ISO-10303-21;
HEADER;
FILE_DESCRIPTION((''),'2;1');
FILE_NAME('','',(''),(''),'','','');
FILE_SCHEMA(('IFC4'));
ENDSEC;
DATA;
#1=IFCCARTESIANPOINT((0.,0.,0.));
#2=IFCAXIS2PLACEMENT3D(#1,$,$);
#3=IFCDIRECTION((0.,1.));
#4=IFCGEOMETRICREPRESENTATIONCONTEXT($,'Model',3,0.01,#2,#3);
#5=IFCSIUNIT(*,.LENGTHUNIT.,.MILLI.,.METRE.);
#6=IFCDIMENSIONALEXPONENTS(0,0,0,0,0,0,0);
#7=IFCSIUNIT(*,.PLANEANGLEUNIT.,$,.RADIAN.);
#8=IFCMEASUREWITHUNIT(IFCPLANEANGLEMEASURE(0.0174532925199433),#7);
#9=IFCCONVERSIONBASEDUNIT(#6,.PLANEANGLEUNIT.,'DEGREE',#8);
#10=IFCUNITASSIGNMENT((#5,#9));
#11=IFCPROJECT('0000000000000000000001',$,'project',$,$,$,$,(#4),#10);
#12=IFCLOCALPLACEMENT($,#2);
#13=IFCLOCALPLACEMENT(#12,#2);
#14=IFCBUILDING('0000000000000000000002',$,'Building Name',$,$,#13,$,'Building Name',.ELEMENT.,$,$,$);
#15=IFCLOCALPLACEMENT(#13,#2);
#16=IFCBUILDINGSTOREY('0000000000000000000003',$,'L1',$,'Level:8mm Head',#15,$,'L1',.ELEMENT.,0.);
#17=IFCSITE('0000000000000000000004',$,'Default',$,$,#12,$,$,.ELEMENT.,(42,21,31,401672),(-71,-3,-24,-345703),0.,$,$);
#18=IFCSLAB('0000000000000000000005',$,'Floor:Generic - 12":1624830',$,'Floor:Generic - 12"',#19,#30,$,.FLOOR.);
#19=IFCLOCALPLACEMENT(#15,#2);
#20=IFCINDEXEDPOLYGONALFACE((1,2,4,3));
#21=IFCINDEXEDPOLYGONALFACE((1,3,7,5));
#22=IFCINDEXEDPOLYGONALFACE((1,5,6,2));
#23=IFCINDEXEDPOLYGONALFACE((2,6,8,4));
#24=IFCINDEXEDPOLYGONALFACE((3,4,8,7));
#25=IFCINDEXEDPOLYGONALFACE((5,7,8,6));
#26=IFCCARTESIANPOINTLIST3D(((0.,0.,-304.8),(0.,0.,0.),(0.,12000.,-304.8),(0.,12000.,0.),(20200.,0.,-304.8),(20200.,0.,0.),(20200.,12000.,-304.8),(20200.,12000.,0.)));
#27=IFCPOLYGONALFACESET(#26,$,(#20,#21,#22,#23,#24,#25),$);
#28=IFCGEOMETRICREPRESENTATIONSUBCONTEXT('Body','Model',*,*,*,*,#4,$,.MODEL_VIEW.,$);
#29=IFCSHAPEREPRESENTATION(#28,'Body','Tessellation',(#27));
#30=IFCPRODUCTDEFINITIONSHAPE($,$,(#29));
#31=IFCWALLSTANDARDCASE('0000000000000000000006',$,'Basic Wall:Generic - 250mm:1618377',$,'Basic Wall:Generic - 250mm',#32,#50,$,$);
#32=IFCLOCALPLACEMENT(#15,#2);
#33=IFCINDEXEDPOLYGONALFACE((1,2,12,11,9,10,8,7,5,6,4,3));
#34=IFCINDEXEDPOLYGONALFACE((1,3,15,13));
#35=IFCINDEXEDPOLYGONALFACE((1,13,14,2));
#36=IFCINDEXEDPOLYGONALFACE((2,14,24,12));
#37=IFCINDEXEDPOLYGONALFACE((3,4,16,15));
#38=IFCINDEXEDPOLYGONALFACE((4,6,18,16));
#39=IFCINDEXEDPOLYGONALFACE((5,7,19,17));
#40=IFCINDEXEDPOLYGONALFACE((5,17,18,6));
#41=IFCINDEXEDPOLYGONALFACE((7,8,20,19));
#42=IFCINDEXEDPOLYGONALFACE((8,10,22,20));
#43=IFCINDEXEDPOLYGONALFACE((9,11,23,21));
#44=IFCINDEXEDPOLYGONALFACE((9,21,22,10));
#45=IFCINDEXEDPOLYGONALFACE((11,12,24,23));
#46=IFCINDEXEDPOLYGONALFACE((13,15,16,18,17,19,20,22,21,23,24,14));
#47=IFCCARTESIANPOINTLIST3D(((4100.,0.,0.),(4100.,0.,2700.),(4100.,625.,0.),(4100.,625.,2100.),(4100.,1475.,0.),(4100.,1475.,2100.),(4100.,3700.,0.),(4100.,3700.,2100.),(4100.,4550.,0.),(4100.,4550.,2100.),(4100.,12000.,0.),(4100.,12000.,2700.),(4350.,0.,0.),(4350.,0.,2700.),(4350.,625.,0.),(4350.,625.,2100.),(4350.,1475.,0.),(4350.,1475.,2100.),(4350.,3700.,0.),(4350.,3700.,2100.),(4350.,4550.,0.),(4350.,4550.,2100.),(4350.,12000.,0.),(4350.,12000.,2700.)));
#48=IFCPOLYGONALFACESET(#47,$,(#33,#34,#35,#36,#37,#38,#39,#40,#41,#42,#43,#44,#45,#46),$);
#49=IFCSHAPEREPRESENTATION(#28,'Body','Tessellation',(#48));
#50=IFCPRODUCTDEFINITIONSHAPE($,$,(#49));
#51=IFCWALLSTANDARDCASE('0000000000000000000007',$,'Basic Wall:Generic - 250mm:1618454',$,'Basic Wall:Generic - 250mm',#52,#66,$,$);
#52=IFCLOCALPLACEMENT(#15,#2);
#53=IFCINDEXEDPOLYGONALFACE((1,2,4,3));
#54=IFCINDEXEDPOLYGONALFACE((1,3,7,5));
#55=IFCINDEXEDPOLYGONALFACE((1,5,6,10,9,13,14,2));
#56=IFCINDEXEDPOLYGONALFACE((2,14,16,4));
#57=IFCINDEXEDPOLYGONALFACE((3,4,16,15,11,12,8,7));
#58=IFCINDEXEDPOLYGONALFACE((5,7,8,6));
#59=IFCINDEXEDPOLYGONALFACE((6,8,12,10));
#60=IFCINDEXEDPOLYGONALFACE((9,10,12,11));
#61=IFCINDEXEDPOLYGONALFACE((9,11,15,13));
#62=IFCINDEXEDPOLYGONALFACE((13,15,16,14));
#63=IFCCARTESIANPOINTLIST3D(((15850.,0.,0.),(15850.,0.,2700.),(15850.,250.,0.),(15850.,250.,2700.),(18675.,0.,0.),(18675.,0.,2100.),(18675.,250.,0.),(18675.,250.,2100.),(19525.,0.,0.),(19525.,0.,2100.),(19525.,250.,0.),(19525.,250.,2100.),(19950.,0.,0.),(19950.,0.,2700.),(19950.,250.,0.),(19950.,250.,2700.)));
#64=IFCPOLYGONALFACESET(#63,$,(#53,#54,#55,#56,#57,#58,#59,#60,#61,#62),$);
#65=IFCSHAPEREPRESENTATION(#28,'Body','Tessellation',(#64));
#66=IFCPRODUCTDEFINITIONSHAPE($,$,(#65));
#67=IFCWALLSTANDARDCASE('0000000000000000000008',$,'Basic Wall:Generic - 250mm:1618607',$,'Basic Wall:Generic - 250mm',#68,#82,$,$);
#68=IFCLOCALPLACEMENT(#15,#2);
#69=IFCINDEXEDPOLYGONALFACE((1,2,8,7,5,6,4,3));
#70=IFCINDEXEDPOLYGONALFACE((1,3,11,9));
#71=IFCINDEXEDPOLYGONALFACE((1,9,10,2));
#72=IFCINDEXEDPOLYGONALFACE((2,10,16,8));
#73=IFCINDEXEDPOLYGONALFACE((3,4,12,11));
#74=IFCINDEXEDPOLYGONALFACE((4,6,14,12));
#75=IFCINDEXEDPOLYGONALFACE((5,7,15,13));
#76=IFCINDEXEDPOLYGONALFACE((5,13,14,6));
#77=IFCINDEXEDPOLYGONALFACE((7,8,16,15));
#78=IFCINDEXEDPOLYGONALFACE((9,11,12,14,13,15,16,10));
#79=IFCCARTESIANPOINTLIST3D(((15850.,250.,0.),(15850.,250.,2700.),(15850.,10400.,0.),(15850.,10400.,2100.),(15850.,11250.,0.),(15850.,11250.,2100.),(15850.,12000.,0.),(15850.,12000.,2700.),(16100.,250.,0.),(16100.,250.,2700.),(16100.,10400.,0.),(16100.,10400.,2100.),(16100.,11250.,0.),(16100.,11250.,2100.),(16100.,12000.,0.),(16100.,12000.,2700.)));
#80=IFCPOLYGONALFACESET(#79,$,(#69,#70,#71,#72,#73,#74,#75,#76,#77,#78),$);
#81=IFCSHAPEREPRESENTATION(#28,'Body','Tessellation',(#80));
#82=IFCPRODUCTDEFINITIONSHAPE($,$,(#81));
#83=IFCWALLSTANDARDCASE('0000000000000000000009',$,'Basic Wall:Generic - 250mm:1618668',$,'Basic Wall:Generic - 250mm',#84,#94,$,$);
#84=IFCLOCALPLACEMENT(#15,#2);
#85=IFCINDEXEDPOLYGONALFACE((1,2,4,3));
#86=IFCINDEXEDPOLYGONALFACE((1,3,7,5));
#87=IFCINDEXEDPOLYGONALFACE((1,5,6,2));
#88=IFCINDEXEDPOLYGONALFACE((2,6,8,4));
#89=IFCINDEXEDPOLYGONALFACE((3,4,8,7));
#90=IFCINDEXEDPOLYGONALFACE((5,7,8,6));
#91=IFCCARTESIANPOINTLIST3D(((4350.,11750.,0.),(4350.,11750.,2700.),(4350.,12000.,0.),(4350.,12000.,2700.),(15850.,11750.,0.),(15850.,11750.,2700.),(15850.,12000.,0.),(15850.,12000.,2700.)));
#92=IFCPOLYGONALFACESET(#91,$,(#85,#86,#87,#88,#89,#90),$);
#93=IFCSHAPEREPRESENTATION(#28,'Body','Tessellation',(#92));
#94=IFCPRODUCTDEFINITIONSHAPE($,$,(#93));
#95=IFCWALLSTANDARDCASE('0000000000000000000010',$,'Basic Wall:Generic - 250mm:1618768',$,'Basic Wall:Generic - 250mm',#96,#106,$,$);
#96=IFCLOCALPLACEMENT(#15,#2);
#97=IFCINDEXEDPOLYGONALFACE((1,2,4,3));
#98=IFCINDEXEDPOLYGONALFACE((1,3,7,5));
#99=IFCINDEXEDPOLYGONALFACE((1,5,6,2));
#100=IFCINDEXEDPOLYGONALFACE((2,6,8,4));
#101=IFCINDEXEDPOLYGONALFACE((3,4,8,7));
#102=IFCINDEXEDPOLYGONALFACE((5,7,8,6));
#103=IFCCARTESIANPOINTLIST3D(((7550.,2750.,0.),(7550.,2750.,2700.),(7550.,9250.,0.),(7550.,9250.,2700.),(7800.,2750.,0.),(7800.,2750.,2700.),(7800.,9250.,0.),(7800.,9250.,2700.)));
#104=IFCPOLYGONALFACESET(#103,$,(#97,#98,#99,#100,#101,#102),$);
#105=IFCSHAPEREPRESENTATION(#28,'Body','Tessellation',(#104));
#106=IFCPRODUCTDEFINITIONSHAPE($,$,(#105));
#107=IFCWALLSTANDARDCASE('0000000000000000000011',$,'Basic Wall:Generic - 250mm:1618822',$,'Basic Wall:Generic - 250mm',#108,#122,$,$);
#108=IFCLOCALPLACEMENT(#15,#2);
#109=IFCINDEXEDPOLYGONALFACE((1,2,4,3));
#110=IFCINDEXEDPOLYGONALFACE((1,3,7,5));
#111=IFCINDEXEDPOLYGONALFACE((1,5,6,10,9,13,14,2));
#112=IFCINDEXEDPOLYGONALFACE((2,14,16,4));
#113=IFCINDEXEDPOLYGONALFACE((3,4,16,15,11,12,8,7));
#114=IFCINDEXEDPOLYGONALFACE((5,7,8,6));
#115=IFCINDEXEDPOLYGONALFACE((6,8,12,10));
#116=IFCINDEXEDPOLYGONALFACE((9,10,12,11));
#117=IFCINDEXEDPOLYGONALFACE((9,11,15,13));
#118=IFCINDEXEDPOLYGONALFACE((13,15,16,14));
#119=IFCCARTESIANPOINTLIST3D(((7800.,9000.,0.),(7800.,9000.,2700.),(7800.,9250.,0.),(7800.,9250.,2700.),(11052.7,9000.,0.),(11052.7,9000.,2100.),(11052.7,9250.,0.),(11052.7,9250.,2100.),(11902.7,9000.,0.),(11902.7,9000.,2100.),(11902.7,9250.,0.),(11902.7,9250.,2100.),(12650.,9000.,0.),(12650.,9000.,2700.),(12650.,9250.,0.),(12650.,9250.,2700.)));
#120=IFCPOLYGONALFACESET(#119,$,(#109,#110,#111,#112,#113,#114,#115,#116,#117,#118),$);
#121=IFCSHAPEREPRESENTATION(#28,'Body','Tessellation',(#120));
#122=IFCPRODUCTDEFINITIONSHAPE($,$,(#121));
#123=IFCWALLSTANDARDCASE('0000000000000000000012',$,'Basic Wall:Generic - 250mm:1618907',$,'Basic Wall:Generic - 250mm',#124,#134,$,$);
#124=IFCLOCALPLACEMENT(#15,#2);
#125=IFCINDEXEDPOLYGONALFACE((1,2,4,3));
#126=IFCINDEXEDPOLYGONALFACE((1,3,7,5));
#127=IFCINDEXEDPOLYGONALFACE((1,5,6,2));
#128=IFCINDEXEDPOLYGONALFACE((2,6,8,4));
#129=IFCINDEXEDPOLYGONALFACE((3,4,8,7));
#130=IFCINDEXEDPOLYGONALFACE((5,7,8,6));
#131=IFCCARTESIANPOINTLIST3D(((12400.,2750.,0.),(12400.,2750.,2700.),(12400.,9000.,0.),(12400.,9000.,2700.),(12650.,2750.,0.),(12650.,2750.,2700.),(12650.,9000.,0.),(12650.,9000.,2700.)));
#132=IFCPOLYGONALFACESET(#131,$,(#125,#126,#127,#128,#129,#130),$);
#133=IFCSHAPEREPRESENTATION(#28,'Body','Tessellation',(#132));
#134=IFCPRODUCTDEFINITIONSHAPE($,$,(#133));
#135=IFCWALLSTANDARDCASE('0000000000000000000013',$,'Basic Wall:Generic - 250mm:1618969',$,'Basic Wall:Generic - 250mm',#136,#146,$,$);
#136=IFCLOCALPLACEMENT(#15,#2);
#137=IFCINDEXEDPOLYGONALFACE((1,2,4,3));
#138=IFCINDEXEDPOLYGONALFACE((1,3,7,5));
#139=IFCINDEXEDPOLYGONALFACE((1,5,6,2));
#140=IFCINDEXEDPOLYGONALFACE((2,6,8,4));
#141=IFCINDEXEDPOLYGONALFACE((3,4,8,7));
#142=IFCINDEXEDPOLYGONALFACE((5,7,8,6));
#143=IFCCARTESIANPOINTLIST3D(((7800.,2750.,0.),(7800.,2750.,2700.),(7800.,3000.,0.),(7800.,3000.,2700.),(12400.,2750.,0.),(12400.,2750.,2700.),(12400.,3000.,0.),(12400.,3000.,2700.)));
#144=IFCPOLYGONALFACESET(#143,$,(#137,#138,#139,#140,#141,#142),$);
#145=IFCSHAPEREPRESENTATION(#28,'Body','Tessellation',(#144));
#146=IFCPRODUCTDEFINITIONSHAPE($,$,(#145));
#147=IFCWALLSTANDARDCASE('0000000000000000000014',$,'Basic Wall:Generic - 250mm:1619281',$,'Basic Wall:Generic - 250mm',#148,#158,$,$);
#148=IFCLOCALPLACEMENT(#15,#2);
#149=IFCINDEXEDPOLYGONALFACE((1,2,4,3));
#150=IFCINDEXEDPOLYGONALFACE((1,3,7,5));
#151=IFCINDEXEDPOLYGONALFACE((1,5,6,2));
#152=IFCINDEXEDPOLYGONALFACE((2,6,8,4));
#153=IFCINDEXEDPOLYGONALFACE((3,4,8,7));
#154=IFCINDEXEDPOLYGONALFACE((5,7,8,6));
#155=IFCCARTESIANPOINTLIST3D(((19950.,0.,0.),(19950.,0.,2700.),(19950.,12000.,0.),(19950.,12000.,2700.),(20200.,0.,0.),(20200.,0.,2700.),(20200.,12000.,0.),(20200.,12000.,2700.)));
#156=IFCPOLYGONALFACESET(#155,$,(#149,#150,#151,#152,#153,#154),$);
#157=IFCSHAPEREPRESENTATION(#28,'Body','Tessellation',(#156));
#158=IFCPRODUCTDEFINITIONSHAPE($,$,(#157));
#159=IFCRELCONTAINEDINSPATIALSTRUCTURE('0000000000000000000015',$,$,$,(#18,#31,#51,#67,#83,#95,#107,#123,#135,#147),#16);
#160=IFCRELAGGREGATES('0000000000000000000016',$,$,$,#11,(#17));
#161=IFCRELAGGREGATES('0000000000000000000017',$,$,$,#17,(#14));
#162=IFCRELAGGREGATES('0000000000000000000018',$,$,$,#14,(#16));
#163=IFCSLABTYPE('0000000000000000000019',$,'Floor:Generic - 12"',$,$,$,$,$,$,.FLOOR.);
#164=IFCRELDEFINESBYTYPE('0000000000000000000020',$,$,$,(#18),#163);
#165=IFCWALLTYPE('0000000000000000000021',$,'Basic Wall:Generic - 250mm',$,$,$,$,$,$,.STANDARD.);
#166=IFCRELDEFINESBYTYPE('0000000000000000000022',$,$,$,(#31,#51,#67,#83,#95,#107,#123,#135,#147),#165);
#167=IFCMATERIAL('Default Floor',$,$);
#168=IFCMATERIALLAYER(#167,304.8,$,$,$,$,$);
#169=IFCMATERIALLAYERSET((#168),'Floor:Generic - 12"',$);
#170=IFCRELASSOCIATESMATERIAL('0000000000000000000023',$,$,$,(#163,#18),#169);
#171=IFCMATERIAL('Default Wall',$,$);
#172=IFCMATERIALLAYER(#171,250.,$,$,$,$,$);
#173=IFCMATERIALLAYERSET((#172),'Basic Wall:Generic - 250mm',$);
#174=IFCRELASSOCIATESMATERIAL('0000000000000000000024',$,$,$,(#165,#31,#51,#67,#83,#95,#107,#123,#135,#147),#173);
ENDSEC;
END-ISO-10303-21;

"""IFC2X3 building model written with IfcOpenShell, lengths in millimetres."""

from ifc_helpers import new_model, entity, si_unit, converted_unit, direction, frame, frame_2d, origin, origin_2d_with_axis, place, context, subcontext, project, spatial, rectangle, extrude, material, layer, layer_set, layer_usage, type_object, element, save


model = new_model("IFC2X3")

# Units and contexts
model_context = context("Model", 3, precision=0.01, world=origin(), true_north=direction((0.0, 1.0)))
body_context = subcontext(model_context, "Body", "Model", "MODEL_VIEW")
ifc_project = project(units=[si_unit("LENGTHUNIT", "METRE", prefix="MILLI"), converted_unit("PLANEANGLEUNIT", "DEGREE", entity("IfcPlaneAngleMeasure", 0.0174532925199433), si_unit("PLANEANGLEUNIT", "RADIAN"), dimensions=[0, 0, 0, 0, 0, 0, 0])], contexts=[model_context])

# Site, building, storey
site_placement = place(None, origin())
site = spatial("IfcSite", under=ifc_project, at=site_placement, Name="Default", CompositionType="ELEMENT", RefLatitude=(42, 21, 31, 401672), RefLongitude=(-71, -3, -24, -345703), RefElevation=0.0)
building_placement = place(site_placement, origin())
building = spatial("IfcBuilding", under=site, at=building_placement, Name="Building Name", LongName="Building Name", CompositionType="ELEMENT")
storey_placement = place(building_placement, origin())
storey = spatial("IfcBuildingStorey", under=building, at=storey_placement, Name="L1", ObjectType="Level:8mm Head", LongName="L1", CompositionType="ELEMENT", Elevation=0.0)

# Slab
ifc_material_1 = material(Name="Default Floor")
ifc_layer_1 = layer(ifc_material_1, 304.8)
ifc_layer_set_1 = layer_set([ifc_layer_1], Name="Floor:Generic - 12\"")
ifc_layer_usage_1 = layer_usage(ifc_layer_set_1, "AXIS3", "POSITIVE", 0.0)
slab_type = type_object("IfcSlabType", Name="Floor:Generic - 12\"", PredefinedType="FLOOR", material=ifc_layer_set_1)
slab_placement = place(storey_placement, origin())
element("IfcSlab", 1, at=slab_placement, inside=storey, type_object=slab_type, material=ifc_layer_usage_1, Name="Floor:Generic - 12\":1624830", ObjectType="Floor:Generic - 12\"", PredefinedType="FLOOR", context=body_context, shape_type="SweptSolid", body=[
    extrude(rectangle(XDim=12000.0, YDim=20200.0, at=origin_2d_with_axis()), frame((10100.0, 6000.0, 0.0), z_axis=(0.0, 0.0, -1.0), x_axis=(0.0, 1.0, 0.0)), (0.0, 0.0, 1.0), 304.8),
])

# Wall, openings
ifc_material_2 = material(Name="Default Wall")
ifc_layer_2 = layer(ifc_material_2, 250.0)
ifc_layer_set_2 = layer_set([ifc_layer_2], Name="Basic Wall:Generic - 250mm")
ifc_layer_usage_2 = layer_usage(ifc_layer_set_2, "AXIS2", "NEGATIVE", 125.0)
wall_type = type_object("IfcWallType", Name="Basic Wall:Generic - 250mm", PredefinedType="STANDARD", material=ifc_layer_set_2)
wall_1_placement = place(storey_placement, frame((4225.0, 12000.0, 0.0), z_axis=(0.0, 0.0, 1.0), x_axis=(0.0, -1.0, 0.0)))
wall_1 = element("IfcWallStandardCase", 2, at=wall_1_placement, inside=storey, type_object=wall_type, material=ifc_layer_usage_2, Name="Basic Wall:Generic - 250mm:1618377", ObjectType="Basic Wall:Generic - 250mm", context=body_context, shape_type="SweptSolid", body=[
    extrude(rectangle(XDim=12000.0, YDim=250.0, at=frame_2d((6000.0, 0.0), x_axis=(1.0, 0.0))), origin(), (0.0, 0.0, 1.0), 2700.0),
])
opening_1_placement = place(wall_1_placement, frame((10525.0, -125.0, 0.0)))
element("IfcOpeningElement", 3, at=opening_1_placement, cuts=wall_1, ObjectType="Opening", context=body_context, shape_type="SweptSolid", body=[
    extrude(rectangle(XDim=2100.0, YDim=850.0, at=frame_2d((1050.0, 425.0), x_axis=(1.0, 0.0))), frame((0.0, 0.0, 0.0), z_axis=(0.0, 1.0, 0.0), x_axis=(0.0, 0.0, 1.0)), (0.0, 0.0, 1.0), 250.0),
])
opening_2_placement = place(wall_1_placement, frame((7450.0, -125.0, 0.0)))
element("IfcOpeningElement", 4, at=opening_2_placement, cuts=wall_1, ObjectType="Opening", context=body_context, shape_type="SweptSolid", body=[
    extrude(rectangle(XDim=2100.0, YDim=850.0, at=frame_2d((1050.0, 425.0), x_axis=(1.0, 0.0))), frame((0.0, 0.0, 0.0), z_axis=(0.0, 1.0, 0.0), x_axis=(0.0, 0.0, 1.0)), (0.0, 0.0, 1.0), 250.0),
])

# Walls, openings
ifc_layer_usage_3 = layer_usage(ifc_layer_set_2, "AXIS2", "NEGATIVE", 125.0)
wall_2_placement = place(storey_placement, frame((15850.0, 125.0, 0.0)))
wall_2 = element("IfcWallStandardCase", 5, at=wall_2_placement, inside=storey, type_object=wall_type, material=ifc_layer_usage_3, Name="Basic Wall:Generic - 250mm:1618454", ObjectType="Basic Wall:Generic - 250mm", context=body_context, shape_type="SweptSolid", body=[
    extrude(rectangle(XDim=4100.0, YDim=250.0, at=frame_2d((2050.0, 0.0), x_axis=(1.0, 0.0))), origin(), (0.0, 0.0, 1.0), 2700.0),
])
opening_3_placement = place(wall_2_placement, frame((2825.0, -125.0, 0.0)))
element("IfcOpeningElement", 6, at=opening_3_placement, cuts=wall_2, ObjectType="Opening", context=body_context, shape_type="SweptSolid", body=[
    extrude(rectangle(XDim=2100.0, YDim=850.0, at=frame_2d((1050.0, 425.0), x_axis=(1.0, 0.0))), frame((0.0, 0.0, 0.0), z_axis=(0.0, 1.0, 0.0), x_axis=(0.0, 0.0, 1.0)), (0.0, 0.0, 1.0), 250.0),
])
ifc_layer_usage_4 = layer_usage(ifc_layer_set_2, "AXIS2", "NEGATIVE", 125.0)
wall_3_placement = place(storey_placement, frame((15975.0, 250.0, 0.0), z_axis=(0.0, 0.0, 1.0), x_axis=(0.0, 1.0, 0.0)))
wall_3 = element("IfcWallStandardCase", 7, at=wall_3_placement, inside=storey, type_object=wall_type, material=ifc_layer_usage_4, Name="Basic Wall:Generic - 250mm:1618607", ObjectType="Basic Wall:Generic - 250mm", context=body_context, shape_type="SweptSolid", body=[
    extrude(rectangle(XDim=11750.0, YDim=250.0, at=frame_2d((5875.0, 0.0), x_axis=(-1.0, 0.0))), origin(), (0.0, 0.0, 1.0), 2700.0),
])
opening_4_placement = place(wall_3_placement, frame((10150.0, -125.0, 0.0)))
element("IfcOpeningElement", 8, at=opening_4_placement, cuts=wall_3, ObjectType="Opening", context=body_context, shape_type="SweptSolid", body=[
    extrude(rectangle(XDim=2100.0, YDim=850.0, at=frame_2d((1050.0, 425.0), x_axis=(1.0, 0.0))), frame((0.0, 0.0, 0.0), z_axis=(0.0, 1.0, 0.0), x_axis=(0.0, 0.0, 1.0)), (0.0, 0.0, 1.0), 250.0),
])

# Walls
ifc_layer_usage_5 = layer_usage(ifc_layer_set_2, "AXIS2", "NEGATIVE", 125.0)
wall_4_placement = place(storey_placement, frame((15850.0, 11875.0, 0.0), z_axis=(0.0, 0.0, 1.0), x_axis=(-1.0, 0.0, 0.0)))
element("IfcWallStandardCase", 9, at=wall_4_placement, inside=storey, type_object=wall_type, material=ifc_layer_usage_5, Name="Basic Wall:Generic - 250mm:1618668", ObjectType="Basic Wall:Generic - 250mm", context=body_context, shape_type="SweptSolid", body=[
    extrude(rectangle(XDim=11500.0, YDim=250.0, at=frame_2d((5750.0, 0.0), x_axis=(-1.0, 0.0))), origin(), (0.0, 0.0, 1.0), 2700.0),
])
ifc_layer_usage_6 = layer_usage(ifc_layer_set_2, "AXIS2", "NEGATIVE", 125.0)
wall_5_placement = place(storey_placement, frame((7675.0, 2750.0, 0.0), z_axis=(0.0, 0.0, 1.0), x_axis=(0.0, 1.0, 0.0)))
element("IfcWallStandardCase", 10, at=wall_5_placement, inside=storey, type_object=wall_type, material=ifc_layer_usage_6, Name="Basic Wall:Generic - 250mm:1618768", ObjectType="Basic Wall:Generic - 250mm", context=body_context, shape_type="SweptSolid", body=[
    extrude(rectangle(XDim=6500.0, YDim=250.0, at=frame_2d((3250.0, 0.0), x_axis=(-1.0, 0.0))), origin(), (0.0, 0.0, 1.0), 2700.0),
])

# Wall, opening
ifc_layer_usage_7 = layer_usage(ifc_layer_set_2, "AXIS2", "NEGATIVE", 125.0)
wall_6_placement = place(storey_placement, frame((7800.0, 9125.0, 0.0)))
wall_6 = element("IfcWallStandardCase", 11, at=wall_6_placement, inside=storey, type_object=wall_type, material=ifc_layer_usage_7, Name="Basic Wall:Generic - 250mm:1618822", ObjectType="Basic Wall:Generic - 250mm", context=body_context, shape_type="SweptSolid", body=[
    extrude(rectangle(XDim=4850.0, YDim=250.0, at=frame_2d((2425.0, 0.0), x_axis=(-1.0, 0.0))), origin(), (0.0, 0.0, 1.0), 2700.0),
])
opening_5_placement = place(wall_6_placement, frame((4102.7, 125.0, 0.0)))
element("IfcOpeningElement", 12, at=opening_5_placement, cuts=wall_6, ObjectType="Opening", context=body_context, shape_type="SweptSolid", body=[
    extrude(rectangle(XDim=2100.0, YDim=850.0, at=frame_2d((1050.0, 425.0), x_axis=(1.0, 0.0))), frame((0.0, 0.0, 0.0), z_axis=(0.0, -1.0, 0.0), x_axis=(0.0, 0.0, 1.0)), (0.0, 0.0, 1.0), 250.0),
])

# Walls
ifc_layer_usage_8 = layer_usage(ifc_layer_set_2, "AXIS2", "NEGATIVE", 125.0)
wall_7_placement = place(storey_placement, frame((12525.0, 9000.0, 0.0), z_axis=(0.0, 0.0, 1.0), x_axis=(0.0, -1.0, 0.0)))
element("IfcWallStandardCase", 13, at=wall_7_placement, inside=storey, type_object=wall_type, material=ifc_layer_usage_8, Name="Basic Wall:Generic - 250mm:1618907", ObjectType="Basic Wall:Generic - 250mm", context=body_context, shape_type="SweptSolid", body=[
    extrude(rectangle(XDim=6250.0, YDim=250.0, at=frame_2d((3125.0, 0.0), x_axis=(-1.0, 0.0))), origin(), (0.0, 0.0, 1.0), 2700.0),
])
ifc_layer_usage_9 = layer_usage(ifc_layer_set_2, "AXIS2", "NEGATIVE", 125.0)
wall_8_placement = place(storey_placement, frame((12400.0, 2875.0, 0.0), z_axis=(0.0, 0.0, 1.0), x_axis=(-1.0, 0.0, 0.0)))
element("IfcWallStandardCase", 14, at=wall_8_placement, inside=storey, type_object=wall_type, material=ifc_layer_usage_9, Name="Basic Wall:Generic - 250mm:1618969", ObjectType="Basic Wall:Generic - 250mm", context=body_context, shape_type="SweptSolid", body=[
    extrude(rectangle(XDim=4600.0, YDim=250.0, at=frame_2d((2300.0, 0.0), x_axis=(-1.0, 0.0))), origin(), (0.0, 0.0, 1.0), 2700.0),
])
ifc_layer_usage_10 = layer_usage(ifc_layer_set_2, "AXIS2", "NEGATIVE", 125.0)
wall_9_placement = place(storey_placement, frame((20075.0, 0.0, 0.0), z_axis=(0.0, 0.0, 1.0), x_axis=(0.0, 1.0, 0.0)))
element("IfcWallStandardCase", 15, at=wall_9_placement, inside=storey, type_object=wall_type, material=ifc_layer_usage_10, Name="Basic Wall:Generic - 250mm:1619281", ObjectType="Basic Wall:Generic - 250mm", context=body_context, shape_type="SweptSolid", body=[
    extrude(rectangle(XDim=12000.0, YDim=250.0, at=frame_2d((6000.0, 0.0), x_axis=(-1.0, 0.0))), origin(), (0.0, 0.0, 1.0), 2700.0),
])

save(model, "model.ifc")
